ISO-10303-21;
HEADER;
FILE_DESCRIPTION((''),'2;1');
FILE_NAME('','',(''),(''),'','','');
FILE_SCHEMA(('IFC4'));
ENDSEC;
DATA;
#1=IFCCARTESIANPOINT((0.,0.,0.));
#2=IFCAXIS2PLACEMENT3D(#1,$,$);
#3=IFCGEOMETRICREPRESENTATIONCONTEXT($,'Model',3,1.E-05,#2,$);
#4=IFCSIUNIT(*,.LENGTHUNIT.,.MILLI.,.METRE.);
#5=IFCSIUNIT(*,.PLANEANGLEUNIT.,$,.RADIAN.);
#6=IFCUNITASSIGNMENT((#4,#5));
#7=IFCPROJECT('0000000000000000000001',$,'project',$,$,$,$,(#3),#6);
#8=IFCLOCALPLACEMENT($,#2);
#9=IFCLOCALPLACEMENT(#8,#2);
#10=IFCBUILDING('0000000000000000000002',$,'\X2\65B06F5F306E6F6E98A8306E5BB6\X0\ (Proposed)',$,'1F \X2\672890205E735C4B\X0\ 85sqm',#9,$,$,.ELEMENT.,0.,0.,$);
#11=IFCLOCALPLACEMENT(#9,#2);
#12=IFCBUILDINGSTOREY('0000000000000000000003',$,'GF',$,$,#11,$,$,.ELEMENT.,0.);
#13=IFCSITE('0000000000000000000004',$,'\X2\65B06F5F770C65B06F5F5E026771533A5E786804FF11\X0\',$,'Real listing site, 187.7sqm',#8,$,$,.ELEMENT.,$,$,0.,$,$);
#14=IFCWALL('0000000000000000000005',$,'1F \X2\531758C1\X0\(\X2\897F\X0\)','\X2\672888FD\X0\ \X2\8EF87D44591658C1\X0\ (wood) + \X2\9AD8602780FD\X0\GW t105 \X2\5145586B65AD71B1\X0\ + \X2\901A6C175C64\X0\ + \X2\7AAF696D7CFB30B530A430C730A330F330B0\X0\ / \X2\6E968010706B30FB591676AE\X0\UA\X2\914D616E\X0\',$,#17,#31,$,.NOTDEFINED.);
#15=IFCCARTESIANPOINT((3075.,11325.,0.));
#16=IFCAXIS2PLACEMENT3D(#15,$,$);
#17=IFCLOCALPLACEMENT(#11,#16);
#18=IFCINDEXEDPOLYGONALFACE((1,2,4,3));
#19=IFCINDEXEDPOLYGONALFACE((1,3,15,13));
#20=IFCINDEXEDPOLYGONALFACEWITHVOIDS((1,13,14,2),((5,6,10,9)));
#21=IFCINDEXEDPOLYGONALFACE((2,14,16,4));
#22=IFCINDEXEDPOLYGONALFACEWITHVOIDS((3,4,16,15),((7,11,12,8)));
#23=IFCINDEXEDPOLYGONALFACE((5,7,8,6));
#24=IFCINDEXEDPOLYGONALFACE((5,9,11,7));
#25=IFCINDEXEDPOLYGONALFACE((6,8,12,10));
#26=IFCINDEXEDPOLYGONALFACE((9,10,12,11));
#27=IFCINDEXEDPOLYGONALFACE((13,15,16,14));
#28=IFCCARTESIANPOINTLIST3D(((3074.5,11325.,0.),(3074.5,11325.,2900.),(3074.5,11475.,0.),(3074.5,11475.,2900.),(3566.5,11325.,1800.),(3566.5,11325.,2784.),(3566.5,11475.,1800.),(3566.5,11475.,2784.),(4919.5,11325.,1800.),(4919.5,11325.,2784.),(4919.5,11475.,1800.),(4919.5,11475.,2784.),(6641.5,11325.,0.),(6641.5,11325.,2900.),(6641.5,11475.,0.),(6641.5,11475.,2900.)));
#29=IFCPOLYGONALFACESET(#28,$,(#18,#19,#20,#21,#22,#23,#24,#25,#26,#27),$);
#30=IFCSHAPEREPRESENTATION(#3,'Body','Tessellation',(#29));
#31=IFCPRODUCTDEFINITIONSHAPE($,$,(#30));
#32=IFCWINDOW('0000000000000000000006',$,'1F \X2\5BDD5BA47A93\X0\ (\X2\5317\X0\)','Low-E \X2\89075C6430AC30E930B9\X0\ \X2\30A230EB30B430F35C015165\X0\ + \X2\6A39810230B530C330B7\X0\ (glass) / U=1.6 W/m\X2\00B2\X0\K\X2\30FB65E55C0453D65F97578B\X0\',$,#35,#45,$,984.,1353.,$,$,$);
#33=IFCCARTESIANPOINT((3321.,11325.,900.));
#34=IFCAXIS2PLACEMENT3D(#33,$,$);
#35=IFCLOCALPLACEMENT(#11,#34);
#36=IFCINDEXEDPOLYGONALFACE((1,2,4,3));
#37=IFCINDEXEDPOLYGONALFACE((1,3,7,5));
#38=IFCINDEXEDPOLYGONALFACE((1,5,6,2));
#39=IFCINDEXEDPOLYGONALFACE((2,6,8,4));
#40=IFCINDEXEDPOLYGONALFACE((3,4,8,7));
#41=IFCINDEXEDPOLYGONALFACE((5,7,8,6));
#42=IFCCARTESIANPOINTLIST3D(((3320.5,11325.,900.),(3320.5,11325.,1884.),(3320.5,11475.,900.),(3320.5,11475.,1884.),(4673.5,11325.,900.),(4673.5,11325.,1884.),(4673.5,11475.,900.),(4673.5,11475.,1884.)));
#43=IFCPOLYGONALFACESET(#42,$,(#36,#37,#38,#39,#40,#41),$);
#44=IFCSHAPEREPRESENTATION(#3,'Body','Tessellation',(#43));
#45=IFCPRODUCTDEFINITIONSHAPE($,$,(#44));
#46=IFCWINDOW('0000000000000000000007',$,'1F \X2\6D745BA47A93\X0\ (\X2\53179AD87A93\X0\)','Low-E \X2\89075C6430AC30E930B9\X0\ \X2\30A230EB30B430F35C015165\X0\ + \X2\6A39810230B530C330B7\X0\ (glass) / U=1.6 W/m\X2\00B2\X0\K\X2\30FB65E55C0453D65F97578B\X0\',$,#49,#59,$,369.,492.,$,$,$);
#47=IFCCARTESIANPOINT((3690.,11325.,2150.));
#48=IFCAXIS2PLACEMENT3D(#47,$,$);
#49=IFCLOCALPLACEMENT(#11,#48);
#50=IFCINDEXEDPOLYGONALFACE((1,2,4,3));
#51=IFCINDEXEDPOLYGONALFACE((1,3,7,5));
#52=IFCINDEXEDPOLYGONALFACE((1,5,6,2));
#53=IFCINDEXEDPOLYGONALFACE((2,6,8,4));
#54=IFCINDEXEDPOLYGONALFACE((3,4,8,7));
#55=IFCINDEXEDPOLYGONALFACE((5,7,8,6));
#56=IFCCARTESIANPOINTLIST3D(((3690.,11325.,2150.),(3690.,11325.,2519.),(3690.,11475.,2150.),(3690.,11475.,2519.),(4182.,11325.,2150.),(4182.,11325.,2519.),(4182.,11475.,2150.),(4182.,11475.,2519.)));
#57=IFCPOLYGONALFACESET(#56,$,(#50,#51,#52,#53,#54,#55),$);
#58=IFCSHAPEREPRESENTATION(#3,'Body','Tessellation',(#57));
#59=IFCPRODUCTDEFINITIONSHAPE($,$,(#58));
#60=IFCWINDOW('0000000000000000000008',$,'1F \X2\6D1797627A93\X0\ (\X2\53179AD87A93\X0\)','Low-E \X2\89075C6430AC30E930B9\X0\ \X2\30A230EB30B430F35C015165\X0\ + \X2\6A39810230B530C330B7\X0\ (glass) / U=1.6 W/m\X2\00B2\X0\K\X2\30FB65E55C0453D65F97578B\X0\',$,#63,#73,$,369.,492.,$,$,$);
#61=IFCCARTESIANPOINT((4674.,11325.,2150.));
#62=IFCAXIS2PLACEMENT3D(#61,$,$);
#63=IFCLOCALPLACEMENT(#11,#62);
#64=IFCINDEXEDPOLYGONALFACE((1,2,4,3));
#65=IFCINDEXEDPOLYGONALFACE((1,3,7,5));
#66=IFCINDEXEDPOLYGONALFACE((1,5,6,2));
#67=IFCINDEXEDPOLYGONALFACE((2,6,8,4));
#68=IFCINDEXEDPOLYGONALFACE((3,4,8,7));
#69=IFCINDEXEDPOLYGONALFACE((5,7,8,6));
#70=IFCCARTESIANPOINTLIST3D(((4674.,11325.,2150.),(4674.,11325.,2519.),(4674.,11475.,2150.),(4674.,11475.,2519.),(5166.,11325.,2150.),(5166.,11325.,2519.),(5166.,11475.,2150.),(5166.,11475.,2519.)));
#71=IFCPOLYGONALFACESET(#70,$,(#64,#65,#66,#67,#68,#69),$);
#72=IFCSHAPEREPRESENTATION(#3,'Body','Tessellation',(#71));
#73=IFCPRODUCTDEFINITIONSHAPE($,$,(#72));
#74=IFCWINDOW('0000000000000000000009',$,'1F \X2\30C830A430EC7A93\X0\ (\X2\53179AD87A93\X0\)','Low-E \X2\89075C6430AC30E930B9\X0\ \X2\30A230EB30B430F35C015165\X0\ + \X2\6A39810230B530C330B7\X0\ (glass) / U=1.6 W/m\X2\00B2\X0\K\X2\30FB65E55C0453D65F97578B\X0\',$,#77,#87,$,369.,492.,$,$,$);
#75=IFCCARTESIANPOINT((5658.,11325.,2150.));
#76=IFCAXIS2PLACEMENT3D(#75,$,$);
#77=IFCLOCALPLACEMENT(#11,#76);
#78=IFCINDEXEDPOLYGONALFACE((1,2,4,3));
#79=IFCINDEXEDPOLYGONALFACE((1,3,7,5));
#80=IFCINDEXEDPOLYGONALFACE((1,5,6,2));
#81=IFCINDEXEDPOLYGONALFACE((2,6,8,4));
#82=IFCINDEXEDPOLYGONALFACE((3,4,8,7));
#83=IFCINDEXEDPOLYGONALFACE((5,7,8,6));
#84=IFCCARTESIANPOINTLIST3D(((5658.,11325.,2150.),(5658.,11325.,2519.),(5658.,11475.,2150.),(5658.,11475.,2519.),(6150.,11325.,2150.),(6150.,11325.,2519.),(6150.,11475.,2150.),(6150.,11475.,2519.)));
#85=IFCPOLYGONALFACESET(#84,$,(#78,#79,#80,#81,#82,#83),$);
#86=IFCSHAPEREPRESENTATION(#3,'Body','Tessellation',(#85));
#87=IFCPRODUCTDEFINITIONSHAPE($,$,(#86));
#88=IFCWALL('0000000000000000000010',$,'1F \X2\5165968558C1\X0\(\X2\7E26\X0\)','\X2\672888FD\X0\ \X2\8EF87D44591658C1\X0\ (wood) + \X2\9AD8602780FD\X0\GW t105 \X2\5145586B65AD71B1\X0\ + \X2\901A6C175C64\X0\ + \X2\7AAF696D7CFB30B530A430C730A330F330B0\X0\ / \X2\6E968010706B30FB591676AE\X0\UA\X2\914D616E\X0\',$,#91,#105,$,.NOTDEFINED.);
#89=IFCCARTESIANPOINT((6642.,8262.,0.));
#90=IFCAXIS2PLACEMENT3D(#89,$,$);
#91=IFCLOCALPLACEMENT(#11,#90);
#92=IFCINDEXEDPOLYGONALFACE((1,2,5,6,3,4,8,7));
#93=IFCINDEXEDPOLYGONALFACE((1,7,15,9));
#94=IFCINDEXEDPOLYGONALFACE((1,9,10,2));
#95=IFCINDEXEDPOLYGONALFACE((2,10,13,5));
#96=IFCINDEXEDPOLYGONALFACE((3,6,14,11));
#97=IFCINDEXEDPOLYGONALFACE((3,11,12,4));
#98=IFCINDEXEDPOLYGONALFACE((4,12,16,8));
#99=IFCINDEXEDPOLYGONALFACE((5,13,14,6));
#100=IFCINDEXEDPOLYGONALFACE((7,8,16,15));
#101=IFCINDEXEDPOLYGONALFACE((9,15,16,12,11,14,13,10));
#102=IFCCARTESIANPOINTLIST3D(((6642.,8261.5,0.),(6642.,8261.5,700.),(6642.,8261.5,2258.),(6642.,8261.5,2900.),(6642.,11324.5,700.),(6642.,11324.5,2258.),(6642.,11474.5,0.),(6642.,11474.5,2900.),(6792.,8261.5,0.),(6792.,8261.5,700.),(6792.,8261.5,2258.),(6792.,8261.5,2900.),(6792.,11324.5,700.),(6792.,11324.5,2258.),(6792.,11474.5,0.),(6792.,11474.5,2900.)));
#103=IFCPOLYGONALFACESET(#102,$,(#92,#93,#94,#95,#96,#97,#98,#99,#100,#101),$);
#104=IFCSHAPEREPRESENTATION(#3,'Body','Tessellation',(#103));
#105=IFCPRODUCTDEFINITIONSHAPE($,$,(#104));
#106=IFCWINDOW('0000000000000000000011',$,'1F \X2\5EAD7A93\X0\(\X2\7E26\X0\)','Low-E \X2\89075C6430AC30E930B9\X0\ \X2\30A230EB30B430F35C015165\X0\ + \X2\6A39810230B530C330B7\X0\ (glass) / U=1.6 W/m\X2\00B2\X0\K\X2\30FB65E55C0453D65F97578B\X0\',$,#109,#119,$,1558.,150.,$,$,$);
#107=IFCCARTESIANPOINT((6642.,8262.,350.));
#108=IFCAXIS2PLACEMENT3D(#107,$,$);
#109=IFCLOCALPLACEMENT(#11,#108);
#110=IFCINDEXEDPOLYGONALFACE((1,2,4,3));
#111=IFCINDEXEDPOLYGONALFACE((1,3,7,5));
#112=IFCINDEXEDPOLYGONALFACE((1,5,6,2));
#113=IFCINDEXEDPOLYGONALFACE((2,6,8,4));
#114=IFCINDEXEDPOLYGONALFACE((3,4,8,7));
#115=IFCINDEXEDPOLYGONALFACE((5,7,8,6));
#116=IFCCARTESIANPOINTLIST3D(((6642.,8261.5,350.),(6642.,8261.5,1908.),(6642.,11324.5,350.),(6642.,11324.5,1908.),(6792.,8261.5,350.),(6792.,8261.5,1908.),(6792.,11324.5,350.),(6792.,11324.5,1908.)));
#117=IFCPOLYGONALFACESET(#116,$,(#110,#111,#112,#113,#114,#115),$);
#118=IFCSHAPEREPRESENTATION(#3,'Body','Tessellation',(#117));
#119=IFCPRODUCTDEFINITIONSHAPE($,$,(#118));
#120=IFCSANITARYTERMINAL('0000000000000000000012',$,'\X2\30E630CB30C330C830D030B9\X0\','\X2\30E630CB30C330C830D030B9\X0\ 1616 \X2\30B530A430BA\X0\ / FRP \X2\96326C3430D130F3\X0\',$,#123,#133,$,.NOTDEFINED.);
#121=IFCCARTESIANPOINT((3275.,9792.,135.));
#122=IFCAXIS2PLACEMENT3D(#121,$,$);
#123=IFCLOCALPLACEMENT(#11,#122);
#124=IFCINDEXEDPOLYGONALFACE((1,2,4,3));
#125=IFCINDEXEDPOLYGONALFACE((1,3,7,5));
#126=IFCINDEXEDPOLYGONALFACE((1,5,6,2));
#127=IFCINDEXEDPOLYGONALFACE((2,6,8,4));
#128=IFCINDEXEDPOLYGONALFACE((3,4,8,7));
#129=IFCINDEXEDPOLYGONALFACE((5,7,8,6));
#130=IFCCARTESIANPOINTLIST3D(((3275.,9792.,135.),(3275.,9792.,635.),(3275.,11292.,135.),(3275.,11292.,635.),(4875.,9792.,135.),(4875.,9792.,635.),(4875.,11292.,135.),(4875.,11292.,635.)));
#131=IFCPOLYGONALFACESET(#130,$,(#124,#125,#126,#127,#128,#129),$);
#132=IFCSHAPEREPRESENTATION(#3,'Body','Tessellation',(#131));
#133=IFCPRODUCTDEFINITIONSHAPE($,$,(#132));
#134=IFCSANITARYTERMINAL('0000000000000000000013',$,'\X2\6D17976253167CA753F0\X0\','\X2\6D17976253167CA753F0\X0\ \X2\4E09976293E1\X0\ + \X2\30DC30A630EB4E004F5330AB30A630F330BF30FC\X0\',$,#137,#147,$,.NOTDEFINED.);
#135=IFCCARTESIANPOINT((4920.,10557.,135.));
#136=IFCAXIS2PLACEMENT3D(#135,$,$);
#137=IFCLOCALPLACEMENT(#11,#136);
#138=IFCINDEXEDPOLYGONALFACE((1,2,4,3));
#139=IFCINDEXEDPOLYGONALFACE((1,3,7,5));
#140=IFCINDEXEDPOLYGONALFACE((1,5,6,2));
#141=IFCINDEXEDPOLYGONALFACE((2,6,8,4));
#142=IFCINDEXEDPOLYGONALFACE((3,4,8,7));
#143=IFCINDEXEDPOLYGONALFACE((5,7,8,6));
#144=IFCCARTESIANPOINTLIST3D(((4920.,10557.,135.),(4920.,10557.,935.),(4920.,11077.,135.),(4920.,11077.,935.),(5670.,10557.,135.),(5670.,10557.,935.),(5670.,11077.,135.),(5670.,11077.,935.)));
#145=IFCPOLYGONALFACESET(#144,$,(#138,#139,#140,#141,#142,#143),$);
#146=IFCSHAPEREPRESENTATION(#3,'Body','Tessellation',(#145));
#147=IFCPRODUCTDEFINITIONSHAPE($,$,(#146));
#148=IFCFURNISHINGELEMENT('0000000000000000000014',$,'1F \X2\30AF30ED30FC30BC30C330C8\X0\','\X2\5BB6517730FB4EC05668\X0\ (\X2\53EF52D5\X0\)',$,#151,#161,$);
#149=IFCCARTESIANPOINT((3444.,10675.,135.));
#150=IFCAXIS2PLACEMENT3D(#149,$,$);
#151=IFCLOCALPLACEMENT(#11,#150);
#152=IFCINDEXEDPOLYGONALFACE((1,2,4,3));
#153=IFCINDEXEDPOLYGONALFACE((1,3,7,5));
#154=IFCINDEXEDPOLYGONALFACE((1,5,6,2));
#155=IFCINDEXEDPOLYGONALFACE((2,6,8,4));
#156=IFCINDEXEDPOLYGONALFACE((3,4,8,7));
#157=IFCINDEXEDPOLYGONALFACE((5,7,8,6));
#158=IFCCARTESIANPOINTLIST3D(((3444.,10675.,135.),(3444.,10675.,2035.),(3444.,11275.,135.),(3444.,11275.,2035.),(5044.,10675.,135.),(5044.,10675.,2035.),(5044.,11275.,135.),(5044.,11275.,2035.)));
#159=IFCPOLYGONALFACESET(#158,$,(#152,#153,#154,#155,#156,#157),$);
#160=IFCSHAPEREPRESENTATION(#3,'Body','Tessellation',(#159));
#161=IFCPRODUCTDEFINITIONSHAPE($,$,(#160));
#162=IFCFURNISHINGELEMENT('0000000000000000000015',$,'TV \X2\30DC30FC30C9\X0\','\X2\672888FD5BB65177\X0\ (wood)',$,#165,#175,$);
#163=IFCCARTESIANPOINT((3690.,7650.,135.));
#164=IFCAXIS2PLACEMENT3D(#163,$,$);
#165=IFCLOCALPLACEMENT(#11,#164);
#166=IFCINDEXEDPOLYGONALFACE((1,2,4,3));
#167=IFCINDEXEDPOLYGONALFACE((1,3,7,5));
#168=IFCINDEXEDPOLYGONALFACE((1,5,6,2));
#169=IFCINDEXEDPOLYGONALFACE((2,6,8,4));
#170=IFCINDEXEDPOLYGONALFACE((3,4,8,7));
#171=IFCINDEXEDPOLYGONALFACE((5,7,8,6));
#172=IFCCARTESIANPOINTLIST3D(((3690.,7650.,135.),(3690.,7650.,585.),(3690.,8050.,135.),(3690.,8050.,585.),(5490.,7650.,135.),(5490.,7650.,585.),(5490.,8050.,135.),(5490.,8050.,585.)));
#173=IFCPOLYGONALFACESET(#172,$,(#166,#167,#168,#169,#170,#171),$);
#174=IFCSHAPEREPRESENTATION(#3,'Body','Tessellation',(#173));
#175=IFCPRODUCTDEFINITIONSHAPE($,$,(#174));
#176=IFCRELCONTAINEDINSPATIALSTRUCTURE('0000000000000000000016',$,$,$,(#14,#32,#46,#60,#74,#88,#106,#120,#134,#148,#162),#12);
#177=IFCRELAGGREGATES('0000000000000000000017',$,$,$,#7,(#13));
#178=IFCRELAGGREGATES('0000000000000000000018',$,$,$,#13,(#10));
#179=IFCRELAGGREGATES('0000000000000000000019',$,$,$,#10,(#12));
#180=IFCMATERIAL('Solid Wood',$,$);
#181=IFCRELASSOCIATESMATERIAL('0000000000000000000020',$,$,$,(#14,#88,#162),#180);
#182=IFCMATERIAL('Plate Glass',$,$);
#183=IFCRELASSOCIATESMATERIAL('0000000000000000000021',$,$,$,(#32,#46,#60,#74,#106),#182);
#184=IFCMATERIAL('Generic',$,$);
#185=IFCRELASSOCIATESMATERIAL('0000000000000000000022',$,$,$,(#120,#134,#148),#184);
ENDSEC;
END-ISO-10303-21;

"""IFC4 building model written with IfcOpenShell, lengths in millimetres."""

from ifc_helpers import new_model, si_unit, frame, frame_2d, origin, place, context, project, spatial, rectangle, extrude, material, element, fill, save


model = new_model("IFC4")

# Units and contexts
model_context = context("Model", 3, precision=1e-05, world=origin())
ifc_project = project(units=[si_unit("LENGTHUNIT", "METRE", prefix="MILLI"), si_unit("PLANEANGLEUNIT", "RADIAN")], contexts=[model_context])

# Site, building, storey
site_placement = place(None, origin())
site = spatial("IfcSite", under=ifc_project, at=site_placement, Name="新潟県新潟市東区幸栄１", ObjectType="Real listing site, 187.7sqm", CompositionType="ELEMENT", RefElevation=0.0)
building_placement = place(site_placement, origin())
building = spatial("IfcBuilding", under=site, at=building_placement, Name="新潟の潮風の家 (Proposed)", ObjectType="1F 木造平屋 85sqm", CompositionType="ELEMENT", ElevationOfRefHeight=0.0, ElevationOfTerrain=0.0)
storey_placement = place(building_placement, origin())
storey = spatial("IfcBuildingStorey", under=building, at=storey_placement, Name="GF", CompositionType="ELEMENT", Elevation=0.0)

# Shared definitions
ifc_material_1 = material(Name="Solid Wood")

# Wall, openings, windows
wall_1_placement = place(storey_placement, frame((3075.0, 11325.0, 0.0)))
wall_1 = element("IfcWall", 1, at=wall_1_placement, inside=storey, material=ifc_material_1, Name="1F 北壁(西)", Description="木製 軸組外壁 (wood) + 高性能GW t105 充填断熱 + 通気層 + 窯業系サイディング / 準耐火・外皮UA配慮", PredefinedType="NOTDEFINED", context=model_context, shape_type="SweptSolid", body=[
    extrude(rectangle(XDim=3567.0, YDim=150.0, at=frame_2d((1783.0, 75.0))), frame((3075.0, 11325.0, 0.0)), (0.0, 0.0, 1.0), 2900.0),
])
opening_1_placement = place(storey_placement, frame((3321.0, 11325.0, 900.0)))
opening_1 = element("IfcOpeningElement", 2, at=opening_1_placement, cuts=wall_1, PredefinedType="NOTDEFINED", context=model_context, shape_type="SweptSolid", body=[
    extrude(rectangle(XDim=1353.0, YDim=150.0, at=frame_2d((676.0, 75.0))), frame((3321.0, 11325.0, 900.0)), (0.0, 0.0, 1.0), 984.0),
])
opening_2_placement = place(storey_placement, frame((3690.0, 11325.0, 2150.0)))
opening_2 = element("IfcOpeningElement", 3, at=opening_2_placement, cuts=wall_1, PredefinedType="NOTDEFINED", context=model_context, shape_type="SweptSolid", body=[
    extrude(rectangle(XDim=492.0, YDim=150.0, at=frame_2d((246.0, 75.0))), frame((3690.0, 11325.0, 2150.0)), (0.0, 0.0, 1.0), 369.0),
])
opening_3_placement = place(storey_placement, frame((4674.0, 11325.0, 2150.0)))
opening_3 = element("IfcOpeningElement", 4, at=opening_3_placement, cuts=wall_1, PredefinedType="NOTDEFINED", context=model_context, shape_type="SweptSolid", body=[
    extrude(rectangle(XDim=492.0, YDim=150.0, at=frame_2d((246.0, 75.0))), frame((4674.0, 11325.0, 2150.0)), (0.0, 0.0, 1.0), 369.0),
])
opening_4_placement = place(storey_placement, frame((5658.0, 11325.0, 2150.0)))
opening_4 = element("IfcOpeningElement", 5, at=opening_4_placement, cuts=wall_1, PredefinedType="NOTDEFINED", context=model_context, shape_type="SweptSolid", body=[
    extrude(rectangle(XDim=492.0, YDim=150.0, at=frame_2d((246.0, 75.0))), frame((5658.0, 11325.0, 2150.0)), (0.0, 0.0, 1.0), 369.0),
])
ifc_material_2 = material(Name="Plate Glass")
window_1_placement = place(storey_placement, frame((3321.0, 11325.0, 900.0)))
window_1 = element("IfcWindow", 6, at=window_1_placement, inside=storey, material=ifc_material_2, Name="1F 寝室窓 (北)", Description="Low-E 複層ガラス アルゴン封入 + 樹脂サッシ (glass) / U=1.6 W/m²K・日射取得型", OverallHeight=984.0, OverallWidth=1353.0, context=model_context, shape_type="SweptSolid", body=[
    extrude(rectangle(XDim=1353.0, YDim=150.0, at=frame_2d((676.0, 75.0))), frame((3321.0, 11325.0, 900.0)), (0.0, 0.0, 1.0), 984.0),
])
fill(opening_1, window_1)
window_2_placement = place(storey_placement, frame((3690.0, 11325.0, 2150.0)))
window_2 = element("IfcWindow", 7, at=window_2_placement, inside=storey, material=ifc_material_2, Name="1F 浴室窓 (北高窓)", Description="Low-E 複層ガラス アルゴン封入 + 樹脂サッシ (glass) / U=1.6 W/m²K・日射取得型", OverallHeight=369.0, OverallWidth=492.0, context=model_context, shape_type="SweptSolid", body=[
    extrude(rectangle(XDim=492.0, YDim=150.0, at=frame_2d((246.0, 75.0))), frame((3690.0, 11325.0, 2150.0)), (0.0, 0.0, 1.0), 369.0),
])
fill(opening_2, window_2)
window_3_placement = place(storey_placement, frame((4674.0, 11325.0, 2150.0)))
window_3 = element("IfcWindow", 8, at=window_3_placement, inside=storey, material=ifc_material_2, Name="1F 洗面窓 (北高窓)", Description="Low-E 複層ガラス アルゴン封入 + 樹脂サッシ (glass) / U=1.6 W/m²K・日射取得型", OverallHeight=369.0, OverallWidth=492.0, context=model_context, shape_type="SweptSolid", body=[
    extrude(rectangle(XDim=492.0, YDim=150.0, at=frame_2d((246.0, 75.0))), frame((4674.0, 11325.0, 2150.0)), (0.0, 0.0, 1.0), 369.0),
])
fill(opening_3, window_3)
window_4_placement = place(storey_placement, frame((5658.0, 11325.0, 2150.0)))
window_4 = element("IfcWindow", 9, at=window_4_placement, inside=storey, material=ifc_material_2, Name="1F トイレ窓 (北高窓)", Description="Low-E 複層ガラス アルゴン封入 + 樹脂サッシ (glass) / U=1.6 W/m²K・日射取得型", OverallHeight=369.0, OverallWidth=492.0, context=model_context, shape_type="SweptSolid", body=[
    extrude(rectangle(XDim=492.0, YDim=150.0, at=frame_2d((246.0, 75.0))), frame((5658.0, 11325.0, 2150.0)), (0.0, 0.0, 1.0), 369.0),
])
fill(opening_4, window_4)

# Wall, opening, window
wall_2_placement = place(storey_placement, frame((6642.0, 8262.0, 0.0)))
wall_2 = element("IfcWall", 10, at=wall_2_placement, inside=storey, material=ifc_material_1, Name="1F 入隅壁(縦)", Description="木製 軸組外壁 (wood) + 高性能GW t105 充填断熱 + 通気層 + 窯業系サイディング / 準耐火・外皮UA配慮", PredefinedType="NOTDEFINED", context=model_context, shape_type="SweptSolid", body=[
    extrude(rectangle(XDim=150.0, YDim=3213.0, at=frame_2d((75.0, 1606.0))), frame((6642.0, 8262.0, 0.0)), (0.0, 0.0, 1.0), 2900.0),
])
opening_5_placement = place(storey_placement, frame((6642.0, 8262.0, 350.0)))
opening_5 = element("IfcOpeningElement", 11, at=opening_5_placement, cuts=wall_2, PredefinedType="NOTDEFINED", context=model_context, shape_type="SweptSolid", body=[
    extrude(rectangle(XDim=150.0, YDim=3063.0, at=frame_2d((75.0, 1531.0))), frame((6642.0, 8262.0, 350.0)), (0.0, 0.0, 1.0), 1558.0),
])
window_5_placement = place(storey_placement, frame((6642.0, 8262.0, 350.0)))
window_5 = element("IfcWindow", 12, at=window_5_placement, inside=storey, material=ifc_material_2, Name="1F 庭窓(縦)", Description="Low-E 複層ガラス アルゴン封入 + 樹脂サッシ (glass) / U=1.6 W/m²K・日射取得型", OverallHeight=1558.0, OverallWidth=150.0, context=model_context, shape_type="SweptSolid", body=[
    extrude(rectangle(XDim=150.0, YDim=3063.0, at=frame_2d((75.0, 1531.0))), frame((6642.0, 8262.0, 350.0)), (0.0, 0.0, 1.0), 1558.0),
])
fill(opening_5, window_5)

# Shared definitions
ifc_material_3 = material(Name="Generic")

# Sanitary terminals
sanitary_terminal_1_placement = place(storey_placement, frame((3275.0, 9792.0, 135.0)))
element("IfcSanitaryTerminal", 13, at=sanitary_terminal_1_placement, inside=storey, material=ifc_material_3, Name="ユニットバス", Description="ユニットバス 1616 サイズ / FRP 防水パン", PredefinedType="NOTDEFINED", context=model_context, shape_type="SweptSolid", body=[
    extrude(rectangle(XDim=1600.0, YDim=1500.0, at=frame_2d((800.0, 750.0))), frame((3275.0, 9792.0, 135.0)), (0.0, 0.0, 1.0), 500.0),
])
sanitary_terminal_2_placement = place(storey_placement, frame((4920.0, 10557.0, 135.0)))
element("IfcSanitaryTerminal", 14, at=sanitary_terminal_2_placement, inside=storey, material=ifc_material_3, Name="洗面化粧台", Description="洗面化粧台 三面鏡 + ボウル一体カウンター", PredefinedType="NOTDEFINED", context=model_context, shape_type="SweptSolid", body=[
    extrude(rectangle(XDim=750.0, YDim=520.0, at=frame_2d((375.0, 260.0))), frame((4920.0, 10557.0, 135.0)), (0.0, 0.0, 1.0), 800.0),
])

# Furnishing elements
furnishing_1_placement = place(storey_placement, frame((3444.0, 10675.0, 135.0)))
element("IfcFurnishingElement", 15, at=furnishing_1_placement, inside=storey, material=ifc_material_3, Name="1F クローゼット", Description="家具・什器 (可動)", context=model_context, shape_type="SweptSolid", body=[
    extrude(rectangle(XDim=1600.0, YDim=600.0, at=frame_2d((800.0, 300.0))), frame((3444.0, 10675.0, 135.0)), (0.0, 0.0, 1.0), 1900.0),
])
furnishing_2_placement = place(storey_placement, frame((3690.0, 7650.0, 135.0)))
element("IfcFurnishingElement", 16, at=furnishing_2_placement, inside=storey, material=ifc_material_1, Name="TV ボード", Description="木製家具 (wood)", context=model_context, shape_type="SweptSolid", body=[
    extrude(rectangle(XDim=1800.0, YDim=400.0, at=frame_2d((900.0, 200.0))), frame((3690.0, 7650.0, 135.0)), (0.0, 0.0, 1.0), 450.0),
])

save(model, "model.ifc")
